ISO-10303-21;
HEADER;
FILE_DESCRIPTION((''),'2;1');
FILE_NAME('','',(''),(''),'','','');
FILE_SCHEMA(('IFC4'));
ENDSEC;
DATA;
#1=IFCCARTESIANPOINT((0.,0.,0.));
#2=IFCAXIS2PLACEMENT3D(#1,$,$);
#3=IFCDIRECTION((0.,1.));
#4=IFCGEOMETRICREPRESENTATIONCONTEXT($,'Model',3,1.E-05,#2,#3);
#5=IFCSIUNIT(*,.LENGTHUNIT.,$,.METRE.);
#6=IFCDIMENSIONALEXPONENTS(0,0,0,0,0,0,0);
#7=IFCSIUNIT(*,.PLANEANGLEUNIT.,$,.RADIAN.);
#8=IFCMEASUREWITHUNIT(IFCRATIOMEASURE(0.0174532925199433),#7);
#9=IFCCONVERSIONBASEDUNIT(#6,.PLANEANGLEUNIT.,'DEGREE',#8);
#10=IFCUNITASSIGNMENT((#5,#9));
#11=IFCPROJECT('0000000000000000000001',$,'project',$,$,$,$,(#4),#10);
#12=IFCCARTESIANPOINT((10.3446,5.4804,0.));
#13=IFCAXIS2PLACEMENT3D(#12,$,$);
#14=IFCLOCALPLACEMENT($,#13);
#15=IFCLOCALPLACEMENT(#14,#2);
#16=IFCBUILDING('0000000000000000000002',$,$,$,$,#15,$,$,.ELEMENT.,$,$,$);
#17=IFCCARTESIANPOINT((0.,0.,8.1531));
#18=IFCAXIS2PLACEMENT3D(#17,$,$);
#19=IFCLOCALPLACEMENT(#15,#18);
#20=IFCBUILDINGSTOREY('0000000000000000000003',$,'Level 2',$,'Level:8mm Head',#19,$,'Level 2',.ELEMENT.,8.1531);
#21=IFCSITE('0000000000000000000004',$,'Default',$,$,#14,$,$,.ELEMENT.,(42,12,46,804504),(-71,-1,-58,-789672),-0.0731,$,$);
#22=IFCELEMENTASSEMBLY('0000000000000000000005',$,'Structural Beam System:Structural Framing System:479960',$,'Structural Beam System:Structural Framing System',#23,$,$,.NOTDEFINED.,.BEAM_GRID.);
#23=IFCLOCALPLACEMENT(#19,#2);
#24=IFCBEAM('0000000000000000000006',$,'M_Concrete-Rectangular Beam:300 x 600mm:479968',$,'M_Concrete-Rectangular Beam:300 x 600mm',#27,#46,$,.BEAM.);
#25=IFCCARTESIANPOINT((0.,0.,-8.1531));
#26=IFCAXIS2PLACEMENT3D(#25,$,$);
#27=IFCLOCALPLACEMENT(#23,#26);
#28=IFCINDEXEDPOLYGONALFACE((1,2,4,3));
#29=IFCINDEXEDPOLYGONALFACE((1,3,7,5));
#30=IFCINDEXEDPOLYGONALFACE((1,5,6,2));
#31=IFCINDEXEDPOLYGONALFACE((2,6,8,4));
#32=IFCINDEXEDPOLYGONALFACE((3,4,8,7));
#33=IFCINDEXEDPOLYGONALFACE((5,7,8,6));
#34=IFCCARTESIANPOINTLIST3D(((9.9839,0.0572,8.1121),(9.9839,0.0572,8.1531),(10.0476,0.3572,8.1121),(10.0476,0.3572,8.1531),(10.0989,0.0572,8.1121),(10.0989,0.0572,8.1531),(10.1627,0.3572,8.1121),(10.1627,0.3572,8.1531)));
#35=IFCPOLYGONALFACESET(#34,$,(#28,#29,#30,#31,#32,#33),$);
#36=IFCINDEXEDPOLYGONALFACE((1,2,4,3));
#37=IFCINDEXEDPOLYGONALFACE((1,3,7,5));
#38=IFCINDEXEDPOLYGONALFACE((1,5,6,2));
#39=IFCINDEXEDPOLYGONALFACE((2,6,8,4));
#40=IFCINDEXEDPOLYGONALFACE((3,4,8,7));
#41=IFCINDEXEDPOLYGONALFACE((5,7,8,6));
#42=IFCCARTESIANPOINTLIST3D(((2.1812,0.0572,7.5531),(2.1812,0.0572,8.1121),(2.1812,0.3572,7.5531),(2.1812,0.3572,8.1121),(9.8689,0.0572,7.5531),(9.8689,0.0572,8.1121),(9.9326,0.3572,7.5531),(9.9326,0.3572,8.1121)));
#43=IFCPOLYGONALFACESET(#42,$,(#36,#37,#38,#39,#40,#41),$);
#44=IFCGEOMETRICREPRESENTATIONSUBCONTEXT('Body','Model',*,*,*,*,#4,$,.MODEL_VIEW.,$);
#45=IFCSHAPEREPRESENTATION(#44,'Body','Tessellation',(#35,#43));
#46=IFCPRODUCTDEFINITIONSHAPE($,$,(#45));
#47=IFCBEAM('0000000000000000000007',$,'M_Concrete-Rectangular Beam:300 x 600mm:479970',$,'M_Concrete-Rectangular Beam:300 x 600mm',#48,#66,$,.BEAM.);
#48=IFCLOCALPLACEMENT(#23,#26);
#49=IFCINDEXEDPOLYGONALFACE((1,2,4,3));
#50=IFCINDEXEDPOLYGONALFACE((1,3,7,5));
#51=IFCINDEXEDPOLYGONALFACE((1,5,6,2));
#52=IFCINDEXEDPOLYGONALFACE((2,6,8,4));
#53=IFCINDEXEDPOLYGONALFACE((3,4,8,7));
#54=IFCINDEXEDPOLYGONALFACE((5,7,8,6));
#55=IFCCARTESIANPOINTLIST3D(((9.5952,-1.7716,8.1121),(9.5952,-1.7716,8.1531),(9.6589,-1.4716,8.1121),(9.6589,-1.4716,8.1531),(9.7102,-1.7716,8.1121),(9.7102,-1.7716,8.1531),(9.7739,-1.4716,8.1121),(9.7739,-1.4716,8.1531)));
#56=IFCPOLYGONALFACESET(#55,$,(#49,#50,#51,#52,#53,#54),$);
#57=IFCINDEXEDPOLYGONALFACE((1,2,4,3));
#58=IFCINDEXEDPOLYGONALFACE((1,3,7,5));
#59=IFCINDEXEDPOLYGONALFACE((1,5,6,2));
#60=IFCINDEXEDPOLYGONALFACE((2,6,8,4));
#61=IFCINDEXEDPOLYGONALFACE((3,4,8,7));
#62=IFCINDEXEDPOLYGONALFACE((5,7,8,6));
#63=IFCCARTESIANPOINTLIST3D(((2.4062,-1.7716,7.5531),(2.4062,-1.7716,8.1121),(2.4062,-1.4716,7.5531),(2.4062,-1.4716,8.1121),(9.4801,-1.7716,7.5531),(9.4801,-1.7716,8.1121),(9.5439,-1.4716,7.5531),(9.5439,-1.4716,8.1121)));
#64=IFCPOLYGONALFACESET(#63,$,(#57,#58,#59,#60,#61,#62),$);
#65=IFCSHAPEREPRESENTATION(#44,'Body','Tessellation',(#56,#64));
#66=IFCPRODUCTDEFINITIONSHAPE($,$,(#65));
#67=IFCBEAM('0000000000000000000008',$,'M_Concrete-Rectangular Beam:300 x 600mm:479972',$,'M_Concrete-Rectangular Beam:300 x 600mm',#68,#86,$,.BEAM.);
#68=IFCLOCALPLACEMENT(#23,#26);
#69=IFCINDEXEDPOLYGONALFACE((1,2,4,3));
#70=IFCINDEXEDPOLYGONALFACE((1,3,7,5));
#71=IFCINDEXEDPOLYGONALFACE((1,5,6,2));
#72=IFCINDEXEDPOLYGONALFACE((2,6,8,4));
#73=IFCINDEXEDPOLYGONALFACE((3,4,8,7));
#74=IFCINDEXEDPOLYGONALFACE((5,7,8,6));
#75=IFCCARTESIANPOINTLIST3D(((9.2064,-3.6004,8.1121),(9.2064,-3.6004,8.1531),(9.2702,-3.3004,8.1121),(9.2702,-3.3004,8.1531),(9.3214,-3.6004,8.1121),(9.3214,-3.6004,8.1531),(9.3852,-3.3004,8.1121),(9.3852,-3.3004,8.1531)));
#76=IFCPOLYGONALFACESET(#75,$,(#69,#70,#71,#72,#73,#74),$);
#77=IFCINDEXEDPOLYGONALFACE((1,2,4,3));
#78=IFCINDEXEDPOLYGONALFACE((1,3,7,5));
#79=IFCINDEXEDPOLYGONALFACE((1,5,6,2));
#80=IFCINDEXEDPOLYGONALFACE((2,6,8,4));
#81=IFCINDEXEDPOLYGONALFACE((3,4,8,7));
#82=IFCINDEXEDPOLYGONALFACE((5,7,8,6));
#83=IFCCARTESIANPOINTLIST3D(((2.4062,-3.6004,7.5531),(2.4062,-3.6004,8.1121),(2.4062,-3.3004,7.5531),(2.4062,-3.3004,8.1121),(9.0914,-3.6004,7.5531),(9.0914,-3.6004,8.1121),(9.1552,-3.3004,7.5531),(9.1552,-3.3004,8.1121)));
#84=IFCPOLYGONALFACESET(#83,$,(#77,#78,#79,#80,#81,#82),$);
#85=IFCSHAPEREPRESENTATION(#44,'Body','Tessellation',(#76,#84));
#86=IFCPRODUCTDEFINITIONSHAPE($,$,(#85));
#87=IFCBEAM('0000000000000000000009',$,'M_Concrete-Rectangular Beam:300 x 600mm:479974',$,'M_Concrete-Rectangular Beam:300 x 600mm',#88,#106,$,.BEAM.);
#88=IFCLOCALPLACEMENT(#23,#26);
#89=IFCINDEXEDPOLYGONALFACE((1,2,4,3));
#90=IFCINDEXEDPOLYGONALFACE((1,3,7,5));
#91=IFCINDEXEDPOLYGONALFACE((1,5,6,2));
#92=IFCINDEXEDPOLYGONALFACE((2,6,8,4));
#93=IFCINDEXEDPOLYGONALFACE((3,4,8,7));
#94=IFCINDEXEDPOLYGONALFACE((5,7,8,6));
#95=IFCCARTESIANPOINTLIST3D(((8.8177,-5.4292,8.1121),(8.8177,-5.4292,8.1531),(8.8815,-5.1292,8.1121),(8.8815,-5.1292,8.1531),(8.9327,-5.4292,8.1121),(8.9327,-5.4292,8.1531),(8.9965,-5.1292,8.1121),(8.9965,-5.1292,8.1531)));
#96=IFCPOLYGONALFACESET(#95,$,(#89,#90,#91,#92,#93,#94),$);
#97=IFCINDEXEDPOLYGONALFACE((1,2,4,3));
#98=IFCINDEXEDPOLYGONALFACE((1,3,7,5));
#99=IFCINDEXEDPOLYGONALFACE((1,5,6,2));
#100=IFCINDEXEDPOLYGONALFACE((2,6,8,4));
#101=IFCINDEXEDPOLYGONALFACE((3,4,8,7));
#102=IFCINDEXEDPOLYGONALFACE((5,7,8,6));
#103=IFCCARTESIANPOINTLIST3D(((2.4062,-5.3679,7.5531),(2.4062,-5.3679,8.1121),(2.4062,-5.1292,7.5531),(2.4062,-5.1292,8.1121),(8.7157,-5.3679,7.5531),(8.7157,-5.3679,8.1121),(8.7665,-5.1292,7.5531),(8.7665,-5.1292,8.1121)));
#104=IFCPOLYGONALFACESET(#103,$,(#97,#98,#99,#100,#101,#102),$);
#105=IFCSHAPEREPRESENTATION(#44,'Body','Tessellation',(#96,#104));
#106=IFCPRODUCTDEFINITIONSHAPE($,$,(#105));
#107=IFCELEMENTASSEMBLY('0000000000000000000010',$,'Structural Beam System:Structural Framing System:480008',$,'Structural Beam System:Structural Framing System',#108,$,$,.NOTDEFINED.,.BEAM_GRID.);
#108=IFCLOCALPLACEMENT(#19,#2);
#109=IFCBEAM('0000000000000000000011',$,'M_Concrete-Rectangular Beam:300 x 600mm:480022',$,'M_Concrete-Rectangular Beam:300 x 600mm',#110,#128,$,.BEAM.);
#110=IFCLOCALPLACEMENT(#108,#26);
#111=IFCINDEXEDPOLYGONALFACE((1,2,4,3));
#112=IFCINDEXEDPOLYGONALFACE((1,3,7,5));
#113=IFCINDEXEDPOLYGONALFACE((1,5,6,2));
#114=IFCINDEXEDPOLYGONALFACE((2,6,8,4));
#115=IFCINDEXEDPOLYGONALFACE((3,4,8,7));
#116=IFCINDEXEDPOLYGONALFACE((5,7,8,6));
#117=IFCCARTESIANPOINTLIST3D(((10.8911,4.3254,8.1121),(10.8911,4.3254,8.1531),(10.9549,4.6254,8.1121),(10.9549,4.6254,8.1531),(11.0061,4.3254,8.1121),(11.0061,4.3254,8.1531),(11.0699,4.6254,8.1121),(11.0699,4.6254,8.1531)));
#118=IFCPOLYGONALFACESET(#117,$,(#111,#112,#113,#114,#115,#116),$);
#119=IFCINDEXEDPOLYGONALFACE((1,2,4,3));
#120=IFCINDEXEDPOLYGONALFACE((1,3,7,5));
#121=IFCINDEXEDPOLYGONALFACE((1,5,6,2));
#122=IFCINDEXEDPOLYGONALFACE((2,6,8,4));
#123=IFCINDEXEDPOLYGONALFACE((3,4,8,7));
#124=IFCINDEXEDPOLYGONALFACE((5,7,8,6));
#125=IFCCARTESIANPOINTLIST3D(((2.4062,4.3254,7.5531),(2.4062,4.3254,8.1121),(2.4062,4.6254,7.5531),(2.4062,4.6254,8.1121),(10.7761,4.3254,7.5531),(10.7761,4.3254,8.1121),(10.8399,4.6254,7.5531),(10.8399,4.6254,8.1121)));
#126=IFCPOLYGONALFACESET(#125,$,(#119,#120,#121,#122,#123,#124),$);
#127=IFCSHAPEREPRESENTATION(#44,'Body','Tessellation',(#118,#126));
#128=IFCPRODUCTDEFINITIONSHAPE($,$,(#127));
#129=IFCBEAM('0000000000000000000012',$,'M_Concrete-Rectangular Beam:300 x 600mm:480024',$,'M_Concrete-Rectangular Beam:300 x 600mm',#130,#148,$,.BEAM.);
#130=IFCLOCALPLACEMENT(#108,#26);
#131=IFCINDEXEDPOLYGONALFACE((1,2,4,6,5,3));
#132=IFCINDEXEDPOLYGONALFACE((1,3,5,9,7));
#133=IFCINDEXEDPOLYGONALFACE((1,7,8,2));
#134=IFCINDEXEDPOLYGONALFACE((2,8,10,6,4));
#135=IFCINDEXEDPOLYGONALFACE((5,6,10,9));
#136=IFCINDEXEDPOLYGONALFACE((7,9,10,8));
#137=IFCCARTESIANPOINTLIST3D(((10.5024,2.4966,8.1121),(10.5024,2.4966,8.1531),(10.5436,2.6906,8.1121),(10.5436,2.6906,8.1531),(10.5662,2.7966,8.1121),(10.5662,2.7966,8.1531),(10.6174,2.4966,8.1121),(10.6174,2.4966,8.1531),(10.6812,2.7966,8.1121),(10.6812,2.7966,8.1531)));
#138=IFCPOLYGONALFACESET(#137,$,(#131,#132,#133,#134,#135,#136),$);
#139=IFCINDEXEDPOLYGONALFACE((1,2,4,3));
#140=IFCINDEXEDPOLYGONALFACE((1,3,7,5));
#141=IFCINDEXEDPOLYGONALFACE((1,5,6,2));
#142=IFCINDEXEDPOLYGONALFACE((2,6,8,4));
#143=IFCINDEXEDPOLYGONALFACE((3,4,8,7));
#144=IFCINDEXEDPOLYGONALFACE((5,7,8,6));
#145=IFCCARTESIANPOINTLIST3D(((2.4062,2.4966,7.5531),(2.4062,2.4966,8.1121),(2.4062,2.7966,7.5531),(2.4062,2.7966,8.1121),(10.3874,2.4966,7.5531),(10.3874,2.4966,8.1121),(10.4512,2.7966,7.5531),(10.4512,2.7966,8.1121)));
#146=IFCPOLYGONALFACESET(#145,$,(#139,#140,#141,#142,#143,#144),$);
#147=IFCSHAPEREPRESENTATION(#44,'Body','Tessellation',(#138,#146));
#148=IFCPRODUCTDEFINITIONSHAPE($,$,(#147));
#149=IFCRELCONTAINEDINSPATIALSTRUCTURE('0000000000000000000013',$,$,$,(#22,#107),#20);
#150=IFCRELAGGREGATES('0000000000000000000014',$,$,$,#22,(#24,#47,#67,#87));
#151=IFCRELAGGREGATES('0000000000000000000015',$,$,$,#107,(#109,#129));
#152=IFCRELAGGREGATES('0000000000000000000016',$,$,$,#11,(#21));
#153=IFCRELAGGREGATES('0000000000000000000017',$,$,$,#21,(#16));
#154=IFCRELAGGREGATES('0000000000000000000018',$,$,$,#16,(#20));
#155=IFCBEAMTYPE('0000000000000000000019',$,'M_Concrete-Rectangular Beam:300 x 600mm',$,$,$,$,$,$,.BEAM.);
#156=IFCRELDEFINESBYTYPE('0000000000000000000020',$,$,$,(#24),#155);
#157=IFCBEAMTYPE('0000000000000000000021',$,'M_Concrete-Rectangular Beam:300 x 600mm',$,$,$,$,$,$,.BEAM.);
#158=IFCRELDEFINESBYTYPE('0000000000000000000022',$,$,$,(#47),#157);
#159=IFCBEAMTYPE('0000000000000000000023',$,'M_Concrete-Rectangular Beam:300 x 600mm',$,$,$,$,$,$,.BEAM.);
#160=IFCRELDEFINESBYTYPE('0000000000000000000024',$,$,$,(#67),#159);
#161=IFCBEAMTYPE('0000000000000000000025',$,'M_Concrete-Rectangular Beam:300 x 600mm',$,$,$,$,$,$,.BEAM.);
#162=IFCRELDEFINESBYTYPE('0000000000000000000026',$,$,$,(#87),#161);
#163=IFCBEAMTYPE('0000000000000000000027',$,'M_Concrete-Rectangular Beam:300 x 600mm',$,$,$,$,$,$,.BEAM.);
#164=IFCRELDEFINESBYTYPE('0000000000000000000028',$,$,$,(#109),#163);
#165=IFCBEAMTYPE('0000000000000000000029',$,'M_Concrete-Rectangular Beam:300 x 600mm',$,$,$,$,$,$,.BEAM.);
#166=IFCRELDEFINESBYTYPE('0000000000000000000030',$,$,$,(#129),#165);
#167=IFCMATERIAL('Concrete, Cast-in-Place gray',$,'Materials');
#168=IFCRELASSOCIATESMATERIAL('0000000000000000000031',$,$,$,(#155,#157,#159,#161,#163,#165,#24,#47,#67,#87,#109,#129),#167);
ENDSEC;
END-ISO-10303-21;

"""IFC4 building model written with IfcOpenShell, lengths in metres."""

from ifc_helpers import new_model, entity, si_unit, converted_unit, direction, frame, frame_2d, origin, origin_2d_with_axis, place, context, subcontext, project, spatial, polyline, rectangle, extrude, clip, halfspace, bounded_halfspace, source, transform, mapped, material, material_profile, profile_set, profile_usage, type_object, type_shapes, element, aggregate, save


model = new_model("IFC4")

# Units and contexts
model_context = context("Model", 3, precision=1e-05, world=origin(), true_north=direction((0.0, 1.0)))
body_context = subcontext(model_context, "Body", "Model", "MODEL_VIEW")
ifc_project = project(units=[si_unit("LENGTHUNIT", "METRE"), converted_unit("PLANEANGLEUNIT", "DEGREE", entity("IfcRatioMeasure", 0.0174532925199433), si_unit("PLANEANGLEUNIT", "RADIAN"), dimensions=[0, 0, 0, 0, 0, 0, 0])], contexts=[model_context])

# Site, building, storey
site_placement = place(None, frame((10.3446, 5.4804, 0.0)))
site = spatial("IfcSite", under=ifc_project, at=site_placement, Name="Default", CompositionType="ELEMENT", RefLatitude=(42, 12, 46, 804504), RefLongitude=(-71, -1, -58, -789672), RefElevation=-0.0731)
building_placement = place(site_placement, origin())
building = spatial("IfcBuilding", under=site, at=building_placement, CompositionType="ELEMENT")
storey_placement = place(building_placement, frame((0.0, 0.0, 8.1531)))
storey = spatial("IfcBuildingStorey", under=building, at=storey_placement, Name="Level 2", ObjectType="Level:8mm Head", LongName="Level 2", CompositionType="ELEMENT", Elevation=8.1531)

# Element assemblies, beams
assembly_1_placement = place(storey_placement, origin())
assembly_1 = element("IfcElementAssembly", 1, at=assembly_1_placement, inside=storey, Name="Structural Beam System:Structural Framing System:479960", ObjectType="Structural Beam System:Structural Framing System", AssemblyPlace="NOTDEFINED", PredefinedType="BEAM_GRID")
ifc_material_1 = material(Name="Concrete, Cast-in-Place gray", Category="Materials")
ifc_material_profile = material_profile(ifc_material_1, rectangle(XDim=0.559, YDim=0.3, at=frame_2d((0.0, 0.0), x_axis=(1.0, 0.0))), Name="300 x 600mm")
ifc_profile_set = profile_set([ifc_material_profile], Name="300 x 600mm")
ifc_profile_usage_1 = profile_usage(ifc_profile_set, cardinal=8)
beam_type_1 = type_object("IfcBeamType", Name="M_Concrete-Rectangular Beam:300 x 600mm", PredefinedType="BEAM", material=ifc_profile_set)
shared_shape_1 = source(origin(), body_context, "Body", "Clipping", [
    clip(clip(extrude(rectangle(XDim=0.041, YDim=0.3, at=frame_2d((0.0, 0.0), x_axis=(1.0, 0.0))), frame((9.9839, 0.2072, 8.1326), z_axis=(1.0, 0.0, 0.0), x_axis=(0.0, 0.0, -1.0)), (0.0, 0.0, 1.0), 0.1788), halfspace(frame((10.4473, 2.2371, 8.1121), z_axis=(-0.978148, 0.207912, 0.0), x_axis=(0.0, 0.0, 1.0)), False)), halfspace(frame((10.0872, 0.0023, 8.5239), z_axis=(0.978148, -0.207912, 0.0), x_axis=(0.207912, 0.978148, 0.0)), False)),
    clip(extrude(rectangle(XDim=0.559, YDim=0.3, at=frame_2d((0.0, 0.0), x_axis=(1.0, 0.0))), frame((2.1812, 0.2072, 7.8326), z_axis=(1.0, 0.0, 0.0), x_axis=(0.0, 0.0, -1.0)), (0.0, 0.0, 1.0), 7.7515), halfspace(frame((8.6968, -5.457, 4.5531), z_axis=(0.978148, -0.207912, 0.0), x_axis=(-0.207912, -0.978148, 0.0)), False)),
])
type_shapes(beam_type_1, [shared_shape_1])
beam_1_placement = place(assembly_1_placement, frame((0.0, 0.0, -8.1531)))
beam_1 = element("IfcBeam", 2, at=beam_1_placement, type_object=beam_type_1, material=ifc_profile_usage_1, Name="M_Concrete-Rectangular Beam:300 x 600mm:479968", ObjectType="M_Concrete-Rectangular Beam:300 x 600mm", PredefinedType="BEAM", context=body_context, shape_type="MappedRepresentation", body=[
    mapped(shared_shape_1, transform((0.0, 0.0, 0.0), scale=1.0)),
])
ifc_profile_usage_2 = profile_usage(ifc_profile_set, cardinal=8)
beam_type_2 = type_object("IfcBeamType", Name="M_Concrete-Rectangular Beam:300 x 600mm", PredefinedType="BEAM", material=ifc_profile_set)
shared_shape_2 = source(origin(), body_context, "Body", "Clipping", [
    clip(clip(extrude(rectangle(XDim=0.041, YDim=0.3, at=frame_2d((0.0, 0.0), x_axis=(1.0, 0.0))), frame((9.5952, -1.6216, 8.1326), z_axis=(1.0, 0.0, 0.0), x_axis=(0.0, 0.0, -1.0)), (0.0, 0.0, 1.0), 0.1788), halfspace(frame((10.4473, 2.2371, 8.1121), z_axis=(-0.978148, 0.207912, 0.0), x_axis=(0.0, 0.0, 1.0)), False)), halfspace(frame((9.6985, -1.8265, 8.5239), z_axis=(0.978148, -0.207912, 0.0), x_axis=(0.207912, 0.978148, 0.0)), False)),
    clip(extrude(rectangle(XDim=0.559, YDim=0.3, at=frame_2d((0.0, 0.0), x_axis=(1.0, 0.0))), frame((2.4062, -1.6216, 7.8326), z_axis=(1.0, 0.0, 0.0), x_axis=(0.0, 0.0, -1.0)), (0.0, 0.0, 1.0), 7.1378), halfspace(frame((8.6968, -5.457, 4.5531), z_axis=(0.978148, -0.207912, 0.0), x_axis=(-0.207912, -0.978148, 0.0)), False)),
])
type_shapes(beam_type_2, [shared_shape_2])
beam_2_placement = place(assembly_1_placement, frame((0.0, 0.0, -8.1531)))
beam_2 = element("IfcBeam", 3, at=beam_2_placement, type_object=beam_type_2, material=ifc_profile_usage_2, Name="M_Concrete-Rectangular Beam:300 x 600mm:479970", ObjectType="M_Concrete-Rectangular Beam:300 x 600mm", PredefinedType="BEAM", context=body_context, shape_type="MappedRepresentation", body=[
    mapped(shared_shape_2, transform((0.0, 0.0, 0.0), scale=1.0)),
])
ifc_profile_usage_3 = profile_usage(ifc_profile_set, cardinal=8)
beam_type_3 = type_object("IfcBeamType", Name="M_Concrete-Rectangular Beam:300 x 600mm", PredefinedType="BEAM", material=ifc_profile_set)
shared_shape_3 = source(origin(), body_context, "Body", "Clipping", [
    clip(clip(extrude(rectangle(XDim=0.041, YDim=0.3, at=frame_2d((0.0, 0.0), x_axis=(1.0, 0.0))), frame((9.2064, -3.4504, 8.1326), z_axis=(1.0, 0.0, 0.0), x_axis=(0.0, 0.0, -1.0)), (0.0, 0.0, 1.0), 0.1788), halfspace(frame((10.4473, 2.2371, 8.1121), z_axis=(-0.978148, 0.207912, 0.0), x_axis=(0.0, 0.0, 1.0)), False)), halfspace(frame((9.3098, -3.6553, 8.5239), z_axis=(0.978148, -0.207912, 0.0), x_axis=(0.207912, 0.978148, 0.0)), False)),
    clip(extrude(rectangle(XDim=0.559, YDim=0.3, at=frame_2d((0.0, 0.0), x_axis=(1.0, 0.0))), frame((2.4062, -3.4504, 7.8326), z_axis=(1.0, 0.0, 0.0), x_axis=(0.0, 0.0, -1.0)), (0.0, 0.0, 1.0), 6.749), halfspace(frame((8.6968, -5.457, 4.5531), z_axis=(0.978148, -0.207912, 0.0), x_axis=(-0.207912, -0.978148, 0.0)), False)),
])
type_shapes(beam_type_3, [shared_shape_3])
beam_3_placement = place(assembly_1_placement, frame((0.0, 0.0, -8.1531)))
beam_3 = element("IfcBeam", 4, at=beam_3_placement, type_object=beam_type_3, material=ifc_profile_usage_3, Name="M_Concrete-Rectangular Beam:300 x 600mm:479972", ObjectType="M_Concrete-Rectangular Beam:300 x 600mm", PredefinedType="BEAM", context=body_context, shape_type="MappedRepresentation", body=[
    mapped(shared_shape_3, transform((0.0, 0.0, 0.0), scale=1.0)),
])
ifc_profile_usage_4 = profile_usage(ifc_profile_set, cardinal=8)
beam_type_4 = type_object("IfcBeamType", Name="M_Concrete-Rectangular Beam:300 x 600mm", PredefinedType="BEAM", material=ifc_profile_set)
shared_shape_4 = source(origin(), body_context, "Body", "Clipping", [
    clip(clip(extrude(rectangle(XDim=0.041, YDim=0.3, at=frame_2d((0.0, 0.0), x_axis=(1.0, 0.0))), frame((8.8177, -5.2792, 8.1326), z_axis=(1.0, 0.0, 0.0), x_axis=(0.0, 0.0, -1.0)), (0.0, 0.0, 1.0), 0.1788), halfspace(frame((10.4473, 2.2371, 8.1121), z_axis=(-0.978148, 0.207912, 0.0), x_axis=(0.0, 0.0, 1.0)), False)), halfspace(frame((8.9211, -5.4841, 8.5239), z_axis=(0.978148, -0.207912, 0.0), x_axis=(0.207912, 0.978148, 0.0)), False)),
    clip(extrude(rectangle(XDim=0.559, YDim=0.2387, at=frame_2d((0.0, 0.0), x_axis=(1.0, 0.0))), frame((2.4062, -5.2486, 7.8326), z_axis=(1.0, 0.0, 0.0), x_axis=(0.0, 0.0, -1.0)), (0.0, 0.0, 1.0), 6.3603), halfspace(frame((8.6968, -5.457, 4.5531), z_axis=(0.978148, -0.207912, 0.0), x_axis=(-0.207912, -0.978148, 0.0)), False)),
])
type_shapes(beam_type_4, [shared_shape_4])
beam_4_placement = place(assembly_1_placement, frame((0.0, 0.0, -8.1531)))
beam_4 = element("IfcBeam", 5, at=beam_4_placement, type_object=beam_type_4, material=ifc_profile_usage_4, Name="M_Concrete-Rectangular Beam:300 x 600mm:479974", ObjectType="M_Concrete-Rectangular Beam:300 x 600mm", PredefinedType="BEAM", context=body_context, shape_type="MappedRepresentation", body=[
    mapped(shared_shape_4, transform((0.0, 0.0, 0.0), scale=1.0)),
])
aggregate(assembly_1, [beam_1, beam_2, beam_3, beam_4])
assembly_2_placement = place(storey_placement, origin())
assembly_2 = element("IfcElementAssembly", 6, at=assembly_2_placement, inside=storey, Name="Structural Beam System:Structural Framing System:480008", ObjectType="Structural Beam System:Structural Framing System", AssemblyPlace="NOTDEFINED", PredefinedType="BEAM_GRID")
ifc_profile_usage_5 = profile_usage(ifc_profile_set, cardinal=8)
beam_type_5 = type_object("IfcBeamType", Name="M_Concrete-Rectangular Beam:300 x 600mm", PredefinedType="BEAM", material=ifc_profile_set)
shared_shape_5 = source(origin(), body_context, "Body", "Clipping", [
    clip(clip(extrude(rectangle(XDim=0.041, YDim=0.3, at=frame_2d((0.0, 0.0), x_axis=(1.0, 0.0))), frame((10.8911, 4.4754, 8.1326), z_axis=(1.0, 0.0, 0.0), x_axis=(0.0, 0.0, -1.0)), (0.0, 0.0, 1.0), 0.1788), halfspace(frame((12.1762, 10.3713, 8.1121), z_axis=(-0.978148, 0.207912, 0.0), x_axis=(0.0, 0.0, 1.0)), False)), halfspace(frame((10.9945, 4.2706, 8.5239), z_axis=(0.978148, -0.207912, 0.0), x_axis=(0.207912, 0.978148, 0.0)), False)),
    clip(extrude(rectangle(XDim=0.559, YDim=0.3, at=frame_2d((0.0, 0.0), x_axis=(1.0, 0.0))), frame((2.4062, 4.4754, 7.8326), z_axis=(1.0, 0.0, 0.0), x_axis=(0.0, 0.0, -1.0)), (0.0, 0.0, 1.0), 8.4337), halfspace(frame((8.6968, -5.457, 4.5531), z_axis=(0.978148, -0.207912, 0.0), x_axis=(-0.207912, -0.978148, 0.0)), False)),
])
type_shapes(beam_type_5, [shared_shape_5])
beam_5_placement = place(assembly_2_placement, frame((0.0, 0.0, -8.1531)))
beam_5 = element("IfcBeam", 7, at=beam_5_placement, type_object=beam_type_5, material=ifc_profile_usage_5, Name="M_Concrete-Rectangular Beam:300 x 600mm:480022", ObjectType="M_Concrete-Rectangular Beam:300 x 600mm", PredefinedType="BEAM", context=body_context, shape_type="MappedRepresentation", body=[
    mapped(shared_shape_5, transform((0.0, 0.0, 0.0), scale=1.0)),
])
ifc_profile_usage_6 = profile_usage(ifc_profile_set, cardinal=8)
beam_type_6 = type_object("IfcBeamType", Name="M_Concrete-Rectangular Beam:300 x 600mm", PredefinedType="BEAM", material=ifc_profile_set)
shared_shape_6 = source(origin(), body_context, "Body", "Clipping", [
    clip(clip(clip(extrude(rectangle(XDim=0.041, YDim=0.3, at=origin_2d_with_axis()), frame((10.5024, 2.6466, 8.1326), z_axis=(1.0, 0.0, 0.0), x_axis=(0.0, 0.0, -1.0)), (0.0, 0.0, 1.0), 0.1788), halfspace(frame((10.6058, 2.4418, 8.5239), z_axis=(0.978148, -0.207912, 0.0), x_axis=(0.207912, 0.978148, 0.0)), False)), bounded_halfspace(frame((10.5436, 2.6906, 8.1121), z_axis=(-0.978148, 0.207912, 0.0), x_axis=(0.0, 0.0, 1.0)), False, frame((10.5024, 2.6466, 8.1326), z_axis=(1.0, 0.0, 0.0), x_axis=(0.0, 0.0, -1.0)), polyline([(-0.0205, 0.044), (0.0205, 0.044), (0.0205, -0.15), (-0.0205, -0.15), (-0.0205, 0.044)]))), bounded_halfspace(frame((12.1762, 10.3713, 8.1121), z_axis=(-0.978148, 0.207912, 0.0), x_axis=(0.0, 0.0, 1.0)), False, frame((10.5024, 2.6466, 8.1326), z_axis=(1.0, 0.0, 0.0), x_axis=(0.0, 0.0, -1.0)), polyline([(0.0205, 0.044), (-0.0205, 0.044), (-0.0205, 0.15), (0.0205, 0.15), (0.0205, 0.044)]))),
    clip(extrude(rectangle(XDim=0.559, YDim=0.3, at=frame_2d((0.0, 0.0), x_axis=(1.0, 0.0))), frame((2.4062, 2.6466, 7.8326), z_axis=(1.0, 0.0, 0.0), x_axis=(0.0, 0.0, -1.0)), (0.0, 0.0, 1.0), 8.045), halfspace(frame((8.6968, -5.457, 4.5531), z_axis=(0.978148, -0.207912, 0.0), x_axis=(-0.207912, -0.978148, 0.0)), False)),
])
type_shapes(beam_type_6, [shared_shape_6])
beam_6_placement = place(assembly_2_placement, frame((0.0, 0.0, -8.1531)))
beam_6 = element("IfcBeam", 8, at=beam_6_placement, type_object=beam_type_6, material=ifc_profile_usage_6, Name="M_Concrete-Rectangular Beam:300 x 600mm:480024", ObjectType="M_Concrete-Rectangular Beam:300 x 600mm", PredefinedType="BEAM", context=body_context, shape_type="MappedRepresentation", body=[
    mapped(shared_shape_6, transform((0.0, 0.0, 0.0), scale=1.0)),
])
aggregate(assembly_2, [beam_5, beam_6])

save(model, "model.ifc")
